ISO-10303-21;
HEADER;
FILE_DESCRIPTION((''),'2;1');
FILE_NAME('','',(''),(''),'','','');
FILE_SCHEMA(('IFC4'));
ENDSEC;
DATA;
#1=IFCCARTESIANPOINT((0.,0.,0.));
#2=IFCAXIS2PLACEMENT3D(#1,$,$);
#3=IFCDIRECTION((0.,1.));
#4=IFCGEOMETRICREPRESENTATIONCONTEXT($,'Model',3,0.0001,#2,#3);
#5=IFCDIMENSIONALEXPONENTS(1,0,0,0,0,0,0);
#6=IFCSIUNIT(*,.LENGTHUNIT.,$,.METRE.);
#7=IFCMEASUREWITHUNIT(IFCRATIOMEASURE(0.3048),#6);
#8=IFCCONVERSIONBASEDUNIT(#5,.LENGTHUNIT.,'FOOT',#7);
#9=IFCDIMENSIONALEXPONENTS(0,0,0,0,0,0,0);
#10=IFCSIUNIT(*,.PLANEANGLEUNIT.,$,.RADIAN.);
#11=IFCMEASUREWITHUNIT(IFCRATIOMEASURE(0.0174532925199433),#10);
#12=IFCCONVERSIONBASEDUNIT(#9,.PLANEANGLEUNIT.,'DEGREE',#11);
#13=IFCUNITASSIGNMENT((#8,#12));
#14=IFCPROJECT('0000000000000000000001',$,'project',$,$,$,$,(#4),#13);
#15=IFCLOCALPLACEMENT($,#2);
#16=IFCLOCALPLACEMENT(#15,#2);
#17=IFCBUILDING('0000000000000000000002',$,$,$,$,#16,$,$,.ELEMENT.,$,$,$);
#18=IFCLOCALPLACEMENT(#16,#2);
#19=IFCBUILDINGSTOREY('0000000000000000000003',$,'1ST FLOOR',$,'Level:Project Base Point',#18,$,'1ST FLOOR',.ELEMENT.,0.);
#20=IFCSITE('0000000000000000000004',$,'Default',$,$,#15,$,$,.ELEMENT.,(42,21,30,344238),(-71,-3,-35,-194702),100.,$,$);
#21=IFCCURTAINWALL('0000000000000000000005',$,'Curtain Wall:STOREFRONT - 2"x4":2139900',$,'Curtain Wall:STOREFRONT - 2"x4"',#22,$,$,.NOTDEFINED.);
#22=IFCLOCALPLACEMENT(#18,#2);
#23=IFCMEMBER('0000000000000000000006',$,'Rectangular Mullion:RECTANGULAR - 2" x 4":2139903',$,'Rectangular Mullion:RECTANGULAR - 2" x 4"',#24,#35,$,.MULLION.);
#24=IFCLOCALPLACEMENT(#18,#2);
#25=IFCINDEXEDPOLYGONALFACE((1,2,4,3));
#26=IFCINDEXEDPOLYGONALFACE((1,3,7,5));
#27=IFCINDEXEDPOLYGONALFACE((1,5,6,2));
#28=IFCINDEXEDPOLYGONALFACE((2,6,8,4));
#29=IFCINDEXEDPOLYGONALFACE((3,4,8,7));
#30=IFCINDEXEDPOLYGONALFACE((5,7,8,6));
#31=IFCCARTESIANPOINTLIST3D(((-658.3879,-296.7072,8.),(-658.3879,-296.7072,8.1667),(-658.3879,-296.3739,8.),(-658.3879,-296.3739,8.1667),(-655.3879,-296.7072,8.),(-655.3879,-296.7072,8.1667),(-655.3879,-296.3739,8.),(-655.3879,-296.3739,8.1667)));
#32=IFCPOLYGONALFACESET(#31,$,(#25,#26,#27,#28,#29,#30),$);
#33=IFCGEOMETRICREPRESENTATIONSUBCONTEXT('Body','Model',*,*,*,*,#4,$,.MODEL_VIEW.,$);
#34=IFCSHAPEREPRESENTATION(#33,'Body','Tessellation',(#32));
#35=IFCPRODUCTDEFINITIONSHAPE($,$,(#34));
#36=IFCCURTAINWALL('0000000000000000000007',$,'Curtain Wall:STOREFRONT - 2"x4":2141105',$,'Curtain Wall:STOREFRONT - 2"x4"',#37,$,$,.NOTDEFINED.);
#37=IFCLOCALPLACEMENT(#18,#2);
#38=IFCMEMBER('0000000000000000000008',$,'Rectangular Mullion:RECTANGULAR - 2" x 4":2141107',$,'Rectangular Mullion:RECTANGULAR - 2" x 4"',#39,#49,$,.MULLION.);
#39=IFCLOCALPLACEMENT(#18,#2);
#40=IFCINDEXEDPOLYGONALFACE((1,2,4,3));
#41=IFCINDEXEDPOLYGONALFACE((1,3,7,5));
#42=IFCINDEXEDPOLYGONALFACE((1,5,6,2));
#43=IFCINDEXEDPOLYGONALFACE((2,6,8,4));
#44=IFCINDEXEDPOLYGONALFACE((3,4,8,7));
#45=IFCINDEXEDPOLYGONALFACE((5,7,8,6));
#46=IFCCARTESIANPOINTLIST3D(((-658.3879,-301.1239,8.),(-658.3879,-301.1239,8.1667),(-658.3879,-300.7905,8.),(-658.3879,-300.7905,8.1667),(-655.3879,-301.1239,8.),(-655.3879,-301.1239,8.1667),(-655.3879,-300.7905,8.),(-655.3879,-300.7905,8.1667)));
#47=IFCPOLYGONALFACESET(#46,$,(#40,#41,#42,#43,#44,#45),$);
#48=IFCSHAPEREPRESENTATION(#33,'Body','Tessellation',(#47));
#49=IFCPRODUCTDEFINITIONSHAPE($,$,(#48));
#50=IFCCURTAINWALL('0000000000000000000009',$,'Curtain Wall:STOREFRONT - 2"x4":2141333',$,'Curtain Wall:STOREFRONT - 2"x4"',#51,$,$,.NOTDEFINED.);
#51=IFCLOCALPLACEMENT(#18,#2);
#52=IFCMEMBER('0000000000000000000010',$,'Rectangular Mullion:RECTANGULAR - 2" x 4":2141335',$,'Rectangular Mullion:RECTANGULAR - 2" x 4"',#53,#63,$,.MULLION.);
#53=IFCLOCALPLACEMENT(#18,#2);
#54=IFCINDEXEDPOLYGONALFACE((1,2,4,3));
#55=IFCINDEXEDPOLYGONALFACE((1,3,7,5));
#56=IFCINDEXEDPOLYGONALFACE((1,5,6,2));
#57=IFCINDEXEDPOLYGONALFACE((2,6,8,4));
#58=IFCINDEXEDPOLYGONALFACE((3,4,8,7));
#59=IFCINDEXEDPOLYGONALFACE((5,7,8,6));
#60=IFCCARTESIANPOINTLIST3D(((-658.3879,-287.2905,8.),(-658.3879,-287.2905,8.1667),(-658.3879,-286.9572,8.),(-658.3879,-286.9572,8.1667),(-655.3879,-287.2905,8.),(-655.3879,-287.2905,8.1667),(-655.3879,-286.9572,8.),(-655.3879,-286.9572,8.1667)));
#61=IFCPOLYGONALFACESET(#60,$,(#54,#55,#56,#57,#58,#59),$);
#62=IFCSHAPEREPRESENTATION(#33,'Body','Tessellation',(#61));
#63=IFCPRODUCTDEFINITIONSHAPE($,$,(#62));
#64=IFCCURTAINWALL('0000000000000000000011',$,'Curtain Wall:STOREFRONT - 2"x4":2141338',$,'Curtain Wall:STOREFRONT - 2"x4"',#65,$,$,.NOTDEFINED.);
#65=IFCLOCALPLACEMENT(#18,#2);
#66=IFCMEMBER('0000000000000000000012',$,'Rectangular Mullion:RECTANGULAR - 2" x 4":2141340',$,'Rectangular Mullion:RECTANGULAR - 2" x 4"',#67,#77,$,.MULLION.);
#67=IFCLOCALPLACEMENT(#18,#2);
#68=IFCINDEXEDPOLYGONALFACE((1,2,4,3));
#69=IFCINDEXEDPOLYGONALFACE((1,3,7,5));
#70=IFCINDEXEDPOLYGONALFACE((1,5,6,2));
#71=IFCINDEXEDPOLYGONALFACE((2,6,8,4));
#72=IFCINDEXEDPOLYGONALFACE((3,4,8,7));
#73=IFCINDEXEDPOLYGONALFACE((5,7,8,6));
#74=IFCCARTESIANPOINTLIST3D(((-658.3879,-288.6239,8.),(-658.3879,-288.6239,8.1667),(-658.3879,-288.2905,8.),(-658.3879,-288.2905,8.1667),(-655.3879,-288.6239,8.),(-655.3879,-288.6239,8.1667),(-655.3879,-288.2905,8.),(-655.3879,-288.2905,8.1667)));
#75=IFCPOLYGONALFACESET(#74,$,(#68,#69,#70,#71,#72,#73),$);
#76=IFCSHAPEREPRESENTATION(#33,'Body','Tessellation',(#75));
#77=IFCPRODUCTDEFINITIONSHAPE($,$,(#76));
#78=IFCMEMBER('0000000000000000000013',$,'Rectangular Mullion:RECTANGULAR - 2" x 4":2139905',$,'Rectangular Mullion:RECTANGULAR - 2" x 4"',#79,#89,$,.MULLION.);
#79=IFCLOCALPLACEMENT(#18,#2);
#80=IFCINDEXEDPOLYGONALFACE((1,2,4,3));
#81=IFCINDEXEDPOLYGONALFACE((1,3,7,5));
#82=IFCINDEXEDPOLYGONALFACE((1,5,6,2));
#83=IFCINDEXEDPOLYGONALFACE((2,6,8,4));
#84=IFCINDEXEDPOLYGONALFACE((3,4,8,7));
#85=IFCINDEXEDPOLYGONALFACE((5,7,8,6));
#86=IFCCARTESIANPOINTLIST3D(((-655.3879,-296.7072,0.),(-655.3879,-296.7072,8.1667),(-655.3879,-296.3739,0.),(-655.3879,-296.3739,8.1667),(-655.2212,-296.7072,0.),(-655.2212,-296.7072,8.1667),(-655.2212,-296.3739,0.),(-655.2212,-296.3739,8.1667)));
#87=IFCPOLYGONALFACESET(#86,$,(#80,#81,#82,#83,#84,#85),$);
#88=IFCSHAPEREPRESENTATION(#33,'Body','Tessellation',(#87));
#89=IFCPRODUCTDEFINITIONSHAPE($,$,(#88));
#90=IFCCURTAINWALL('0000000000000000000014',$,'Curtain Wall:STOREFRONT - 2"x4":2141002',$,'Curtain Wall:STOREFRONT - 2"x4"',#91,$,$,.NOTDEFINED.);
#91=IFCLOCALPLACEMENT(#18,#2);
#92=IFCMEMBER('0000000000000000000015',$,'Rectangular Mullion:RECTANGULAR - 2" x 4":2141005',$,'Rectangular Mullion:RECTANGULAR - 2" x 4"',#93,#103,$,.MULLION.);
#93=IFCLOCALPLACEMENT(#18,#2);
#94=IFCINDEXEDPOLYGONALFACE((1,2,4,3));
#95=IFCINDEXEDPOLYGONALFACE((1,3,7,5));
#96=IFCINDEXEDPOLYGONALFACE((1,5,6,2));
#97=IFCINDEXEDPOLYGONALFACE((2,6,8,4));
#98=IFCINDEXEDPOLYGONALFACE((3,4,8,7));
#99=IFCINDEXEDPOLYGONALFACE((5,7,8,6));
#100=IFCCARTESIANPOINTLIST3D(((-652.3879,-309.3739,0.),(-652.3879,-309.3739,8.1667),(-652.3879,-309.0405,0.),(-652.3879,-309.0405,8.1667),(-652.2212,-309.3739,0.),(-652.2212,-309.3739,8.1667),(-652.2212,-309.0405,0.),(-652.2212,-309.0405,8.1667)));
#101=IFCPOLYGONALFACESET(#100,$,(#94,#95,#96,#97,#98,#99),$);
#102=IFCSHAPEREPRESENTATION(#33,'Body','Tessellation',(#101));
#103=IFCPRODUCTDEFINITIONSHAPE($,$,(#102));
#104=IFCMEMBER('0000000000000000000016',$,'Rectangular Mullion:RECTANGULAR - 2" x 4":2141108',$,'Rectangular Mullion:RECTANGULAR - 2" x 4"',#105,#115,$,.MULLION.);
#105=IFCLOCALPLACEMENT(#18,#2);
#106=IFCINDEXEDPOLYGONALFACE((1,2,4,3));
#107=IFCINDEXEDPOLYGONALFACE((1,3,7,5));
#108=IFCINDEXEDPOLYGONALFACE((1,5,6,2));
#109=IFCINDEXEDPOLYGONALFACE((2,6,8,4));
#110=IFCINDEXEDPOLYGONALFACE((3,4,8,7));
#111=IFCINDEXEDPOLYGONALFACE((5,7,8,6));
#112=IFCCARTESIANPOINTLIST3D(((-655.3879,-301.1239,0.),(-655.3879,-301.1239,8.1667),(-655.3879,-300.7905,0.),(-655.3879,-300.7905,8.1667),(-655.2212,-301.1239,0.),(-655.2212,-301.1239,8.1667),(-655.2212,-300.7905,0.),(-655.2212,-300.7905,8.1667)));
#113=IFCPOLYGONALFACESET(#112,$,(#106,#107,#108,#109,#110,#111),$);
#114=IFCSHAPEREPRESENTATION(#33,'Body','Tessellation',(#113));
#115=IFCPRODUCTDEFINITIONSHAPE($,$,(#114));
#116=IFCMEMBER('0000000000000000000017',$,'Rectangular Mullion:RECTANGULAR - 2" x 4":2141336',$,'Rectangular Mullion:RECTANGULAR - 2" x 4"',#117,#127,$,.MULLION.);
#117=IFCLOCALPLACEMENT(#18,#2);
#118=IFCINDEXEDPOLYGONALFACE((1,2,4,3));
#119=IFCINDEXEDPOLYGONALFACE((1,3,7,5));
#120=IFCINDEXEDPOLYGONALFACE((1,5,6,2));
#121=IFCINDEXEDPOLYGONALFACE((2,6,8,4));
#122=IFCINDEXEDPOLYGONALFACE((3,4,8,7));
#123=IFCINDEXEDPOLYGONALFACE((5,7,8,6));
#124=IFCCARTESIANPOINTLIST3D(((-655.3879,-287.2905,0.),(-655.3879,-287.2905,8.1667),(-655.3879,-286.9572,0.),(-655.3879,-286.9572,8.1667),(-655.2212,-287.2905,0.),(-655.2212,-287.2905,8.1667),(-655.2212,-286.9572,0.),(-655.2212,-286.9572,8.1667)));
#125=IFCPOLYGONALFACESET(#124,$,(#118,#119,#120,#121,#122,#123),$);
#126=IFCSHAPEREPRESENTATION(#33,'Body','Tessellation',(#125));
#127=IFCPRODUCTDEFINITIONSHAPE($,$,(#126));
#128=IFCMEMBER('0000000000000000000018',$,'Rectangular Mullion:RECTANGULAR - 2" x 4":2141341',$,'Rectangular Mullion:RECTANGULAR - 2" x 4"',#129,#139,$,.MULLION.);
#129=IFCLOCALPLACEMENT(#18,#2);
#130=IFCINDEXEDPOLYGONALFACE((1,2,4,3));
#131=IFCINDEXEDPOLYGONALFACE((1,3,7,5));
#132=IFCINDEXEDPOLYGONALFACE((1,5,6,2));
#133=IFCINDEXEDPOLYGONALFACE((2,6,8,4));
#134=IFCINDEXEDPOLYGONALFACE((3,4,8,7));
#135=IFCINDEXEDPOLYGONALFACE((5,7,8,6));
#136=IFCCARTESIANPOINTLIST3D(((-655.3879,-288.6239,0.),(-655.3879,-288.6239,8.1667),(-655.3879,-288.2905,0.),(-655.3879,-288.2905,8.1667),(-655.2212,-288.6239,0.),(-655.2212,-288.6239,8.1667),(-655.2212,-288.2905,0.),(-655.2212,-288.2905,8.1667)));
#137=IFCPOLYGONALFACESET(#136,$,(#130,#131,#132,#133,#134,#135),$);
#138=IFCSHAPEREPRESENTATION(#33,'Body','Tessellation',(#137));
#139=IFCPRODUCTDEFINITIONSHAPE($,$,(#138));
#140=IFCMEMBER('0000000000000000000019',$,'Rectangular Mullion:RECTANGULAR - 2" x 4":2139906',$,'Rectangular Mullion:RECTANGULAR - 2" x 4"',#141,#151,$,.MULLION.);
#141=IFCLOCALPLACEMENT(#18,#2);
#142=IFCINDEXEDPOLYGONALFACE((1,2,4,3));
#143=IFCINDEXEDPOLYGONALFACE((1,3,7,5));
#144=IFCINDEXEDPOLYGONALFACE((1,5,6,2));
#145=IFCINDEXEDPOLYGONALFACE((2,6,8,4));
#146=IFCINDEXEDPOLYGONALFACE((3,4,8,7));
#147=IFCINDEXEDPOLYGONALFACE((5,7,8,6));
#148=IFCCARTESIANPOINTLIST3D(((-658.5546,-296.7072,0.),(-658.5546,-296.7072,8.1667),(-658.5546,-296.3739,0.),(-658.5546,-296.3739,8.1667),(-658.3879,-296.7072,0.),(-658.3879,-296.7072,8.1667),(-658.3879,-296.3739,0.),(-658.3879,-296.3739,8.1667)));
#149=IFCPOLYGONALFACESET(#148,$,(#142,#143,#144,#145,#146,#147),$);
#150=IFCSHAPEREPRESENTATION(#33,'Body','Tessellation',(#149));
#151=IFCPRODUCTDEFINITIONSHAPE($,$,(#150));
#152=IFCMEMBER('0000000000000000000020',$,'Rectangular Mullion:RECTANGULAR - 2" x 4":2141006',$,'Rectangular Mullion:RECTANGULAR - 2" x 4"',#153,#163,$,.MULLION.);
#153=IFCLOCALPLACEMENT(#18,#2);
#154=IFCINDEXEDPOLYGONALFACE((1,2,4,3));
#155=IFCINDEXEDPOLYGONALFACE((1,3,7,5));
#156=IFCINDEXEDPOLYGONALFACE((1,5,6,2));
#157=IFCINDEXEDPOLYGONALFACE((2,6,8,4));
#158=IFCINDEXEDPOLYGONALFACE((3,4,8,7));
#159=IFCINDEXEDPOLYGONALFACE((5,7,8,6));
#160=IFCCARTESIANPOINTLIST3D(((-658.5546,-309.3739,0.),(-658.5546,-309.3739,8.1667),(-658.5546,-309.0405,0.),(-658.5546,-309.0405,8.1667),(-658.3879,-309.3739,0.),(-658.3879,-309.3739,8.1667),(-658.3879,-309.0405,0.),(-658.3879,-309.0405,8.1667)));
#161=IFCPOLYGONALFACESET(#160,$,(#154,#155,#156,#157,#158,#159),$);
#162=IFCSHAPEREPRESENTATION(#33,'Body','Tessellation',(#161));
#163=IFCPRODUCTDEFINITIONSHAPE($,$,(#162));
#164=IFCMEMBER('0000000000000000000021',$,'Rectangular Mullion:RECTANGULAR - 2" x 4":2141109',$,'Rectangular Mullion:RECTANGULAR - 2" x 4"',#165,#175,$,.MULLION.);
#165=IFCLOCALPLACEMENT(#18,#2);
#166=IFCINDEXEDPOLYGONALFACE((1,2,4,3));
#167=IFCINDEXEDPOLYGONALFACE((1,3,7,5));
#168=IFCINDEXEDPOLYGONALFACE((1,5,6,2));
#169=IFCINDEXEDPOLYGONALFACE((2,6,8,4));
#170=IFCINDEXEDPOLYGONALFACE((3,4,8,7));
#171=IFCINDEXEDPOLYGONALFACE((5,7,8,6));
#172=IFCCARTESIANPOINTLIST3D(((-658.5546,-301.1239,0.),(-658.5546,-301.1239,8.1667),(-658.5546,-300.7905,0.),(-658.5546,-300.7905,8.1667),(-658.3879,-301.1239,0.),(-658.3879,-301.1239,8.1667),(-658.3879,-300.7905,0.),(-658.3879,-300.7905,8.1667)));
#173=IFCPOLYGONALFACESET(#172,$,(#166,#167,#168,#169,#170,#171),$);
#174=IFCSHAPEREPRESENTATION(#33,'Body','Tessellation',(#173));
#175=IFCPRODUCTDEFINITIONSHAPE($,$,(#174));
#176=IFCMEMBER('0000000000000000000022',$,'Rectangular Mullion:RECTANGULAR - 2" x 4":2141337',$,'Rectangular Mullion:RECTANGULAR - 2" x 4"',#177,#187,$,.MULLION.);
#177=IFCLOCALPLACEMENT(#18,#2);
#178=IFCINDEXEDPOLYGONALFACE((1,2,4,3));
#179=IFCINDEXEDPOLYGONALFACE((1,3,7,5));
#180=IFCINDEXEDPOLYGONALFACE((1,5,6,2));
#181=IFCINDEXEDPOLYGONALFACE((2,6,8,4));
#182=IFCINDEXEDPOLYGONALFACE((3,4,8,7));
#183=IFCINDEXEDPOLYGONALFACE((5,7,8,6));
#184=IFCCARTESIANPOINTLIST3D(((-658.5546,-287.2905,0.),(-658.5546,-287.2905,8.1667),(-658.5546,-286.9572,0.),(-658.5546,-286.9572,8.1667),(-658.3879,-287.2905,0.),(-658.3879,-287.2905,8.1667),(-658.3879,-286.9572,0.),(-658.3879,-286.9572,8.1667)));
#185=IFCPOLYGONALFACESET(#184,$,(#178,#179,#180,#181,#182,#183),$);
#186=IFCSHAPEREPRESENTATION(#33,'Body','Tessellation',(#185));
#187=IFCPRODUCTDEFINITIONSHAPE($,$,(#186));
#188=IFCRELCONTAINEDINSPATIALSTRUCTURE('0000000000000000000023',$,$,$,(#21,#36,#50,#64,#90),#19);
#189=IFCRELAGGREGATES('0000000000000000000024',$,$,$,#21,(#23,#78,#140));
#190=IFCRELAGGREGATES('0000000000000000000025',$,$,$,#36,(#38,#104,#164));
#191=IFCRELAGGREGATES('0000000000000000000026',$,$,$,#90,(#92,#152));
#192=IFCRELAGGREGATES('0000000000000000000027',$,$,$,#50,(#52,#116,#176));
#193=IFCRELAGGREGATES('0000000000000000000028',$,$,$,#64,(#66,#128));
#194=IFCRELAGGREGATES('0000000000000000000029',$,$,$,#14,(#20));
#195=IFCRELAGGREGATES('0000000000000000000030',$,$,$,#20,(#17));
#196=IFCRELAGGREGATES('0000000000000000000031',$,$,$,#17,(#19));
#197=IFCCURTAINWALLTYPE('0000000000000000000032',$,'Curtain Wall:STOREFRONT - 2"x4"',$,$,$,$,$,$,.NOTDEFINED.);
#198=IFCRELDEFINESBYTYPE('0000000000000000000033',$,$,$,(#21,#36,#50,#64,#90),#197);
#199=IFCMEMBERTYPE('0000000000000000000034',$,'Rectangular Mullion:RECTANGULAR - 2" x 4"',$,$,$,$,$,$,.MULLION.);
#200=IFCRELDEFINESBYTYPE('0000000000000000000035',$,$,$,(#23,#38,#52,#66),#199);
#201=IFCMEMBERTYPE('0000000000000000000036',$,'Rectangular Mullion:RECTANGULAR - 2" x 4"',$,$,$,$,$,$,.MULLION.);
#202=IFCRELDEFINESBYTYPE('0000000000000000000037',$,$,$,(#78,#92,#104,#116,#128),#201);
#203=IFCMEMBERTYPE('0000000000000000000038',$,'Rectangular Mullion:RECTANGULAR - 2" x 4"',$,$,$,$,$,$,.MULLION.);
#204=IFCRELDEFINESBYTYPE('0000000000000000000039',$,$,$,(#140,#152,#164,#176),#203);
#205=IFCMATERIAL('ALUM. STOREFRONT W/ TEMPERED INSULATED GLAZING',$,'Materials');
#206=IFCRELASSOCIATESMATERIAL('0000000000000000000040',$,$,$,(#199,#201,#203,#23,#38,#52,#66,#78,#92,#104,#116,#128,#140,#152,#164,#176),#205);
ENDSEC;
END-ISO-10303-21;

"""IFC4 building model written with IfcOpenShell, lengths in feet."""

from ifc_helpers import new_model, entity, si_unit, converted_unit, direction, frame, origin, origin_2d_with_axis, place, context, subcontext, project, spatial, rectangle, extrude, source, transform, mapped, material, material_profile, profile_set, profile_usage, type_object, type_shapes, element, aggregate, save


model = new_model("IFC4")

# Units and contexts
model_context = context("Model", 3, precision=0.0001, world=origin(), true_north=direction((0.0, 1.0)))
body_context = subcontext(model_context, "Body", "Model", "MODEL_VIEW")
ifc_project = project(units=[converted_unit("LENGTHUNIT", "FOOT", entity("IfcRatioMeasure", 0.3048), si_unit("LENGTHUNIT", "METRE"), dimensions=[1, 0, 0, 0, 0, 0, 0]), converted_unit("PLANEANGLEUNIT", "DEGREE", entity("IfcRatioMeasure", 0.0174532925199433), si_unit("PLANEANGLEUNIT", "RADIAN"), dimensions=[0, 0, 0, 0, 0, 0, 0])], contexts=[model_context])

# Site, building, storey
site_placement = place(None, origin())
site = spatial("IfcSite", under=ifc_project, at=site_placement, Name="Default", CompositionType="ELEMENT", RefLatitude=(42, 21, 30, 344238), RefLongitude=(-71, -3, -35, -194702), RefElevation=100.0)
building_placement = place(site_placement, origin())
building = spatial("IfcBuilding", under=site, at=building_placement, CompositionType="ELEMENT")
storey_placement = place(building_placement, origin())
storey = spatial("IfcBuildingStorey", under=building, at=storey_placement, Name="1ST FLOOR", ObjectType="Level:Project Base Point", LongName="1ST FLOOR", CompositionType="ELEMENT", Elevation=0.0)

# Curtain walls, members
curtain_wall_type = type_object("IfcCurtainWallType", Name="Curtain Wall:STOREFRONT - 2\"x4\"", PredefinedType="NOTDEFINED")
curtain_wall_1_placement = place(storey_placement, origin())
curtain_wall_1 = element("IfcCurtainWall", 1, at=curtain_wall_1_placement, inside=storey, type_object=curtain_wall_type, Name="Curtain Wall:STOREFRONT - 2\"x4\":2139900", ObjectType="Curtain Wall:STOREFRONT - 2\"x4\"", PredefinedType="NOTDEFINED")
ifc_material_1 = material(Name="ALUM. STOREFRONT W/ TEMPERED INSULATED GLAZING", Category="Materials")
ifc_material_profile = material_profile(ifc_material_1, rectangle(XDim=0.3333, YDim=0.1667, at=origin_2d_with_axis()), Name="RECTANGULAR - 2\" x 4\"")
ifc_profile_set = profile_set([ifc_material_profile], Name="RECTANGULAR - 2\" x 4\"")
ifc_profile_usage_1 = profile_usage(ifc_profile_set)
member_type_1 = type_object("IfcMemberType", Name="Rectangular Mullion:RECTANGULAR - 2\" x 4\"", PredefinedType="MULLION", material=ifc_profile_set)
shared_shape_1 = source(origin(), body_context, "Body", "SweptSolid", [
    extrude(rectangle(XDim=0.3333, YDim=0.1667, at=origin_2d_with_axis()), frame((-0.0833, 0.0, -3.0), z_axis=(0.0, 0.0, 1.0), x_axis=(0.0, -1.0, 0.0)), (0.0, 0.0, 1.0), 3.0),
])
type_shapes(member_type_1, [shared_shape_1])
member_1_placement = place(storey_placement, frame((-655.3879, -296.5405, 8.1667), z_axis=(1.0, 0.0, 0.0), x_axis=(0.0, 0.0, 1.0)))
member_1 = element("IfcMember", 2, at=member_1_placement, type_object=member_type_1, material=ifc_profile_usage_1, Name="Rectangular Mullion:RECTANGULAR - 2\" x 4\":2139903", ObjectType="Rectangular Mullion:RECTANGULAR - 2\" x 4\"", PredefinedType="MULLION", context=body_context, shape_type="MappedRepresentation", body=[
    mapped(shared_shape_1, transform((0.0, 0.0, 0.0), scale=1.0)),
])
curtain_wall_2_placement = place(storey_placement, origin())
curtain_wall_2 = element("IfcCurtainWall", 3, at=curtain_wall_2_placement, inside=storey, type_object=curtain_wall_type, Name="Curtain Wall:STOREFRONT - 2\"x4\":2141105", ObjectType="Curtain Wall:STOREFRONT - 2\"x4\"", PredefinedType="NOTDEFINED")
ifc_profile_usage_2 = profile_usage(ifc_profile_set)
member_2_placement = place(storey_placement, frame((-655.3879, -300.9572, 8.1667), z_axis=(1.0, 0.0, 0.0), x_axis=(0.0, 0.0, 1.0)))
member_2 = element("IfcMember", 4, at=member_2_placement, type_object=member_type_1, material=ifc_profile_usage_2, Name="Rectangular Mullion:RECTANGULAR - 2\" x 4\":2141107", ObjectType="Rectangular Mullion:RECTANGULAR - 2\" x 4\"", PredefinedType="MULLION", context=body_context, shape_type="MappedRepresentation", body=[
    mapped(shared_shape_1, transform((0.0, 0.0, 0.0), scale=1.0)),
])
curtain_wall_3_placement = place(storey_placement, origin())
curtain_wall_3 = element("IfcCurtainWall", 5, at=curtain_wall_3_placement, inside=storey, type_object=curtain_wall_type, Name="Curtain Wall:STOREFRONT - 2\"x4\":2141333", ObjectType="Curtain Wall:STOREFRONT - 2\"x4\"", PredefinedType="NOTDEFINED")
ifc_profile_usage_3 = profile_usage(ifc_profile_set)
member_3_placement = place(storey_placement, frame((-655.3879, -287.1239, 8.1667), z_axis=(1.0, 0.0, 0.0), x_axis=(0.0, 0.0, 1.0)))
member_3 = element("IfcMember", 6, at=member_3_placement, type_object=member_type_1, material=ifc_profile_usage_3, Name="Rectangular Mullion:RECTANGULAR - 2\" x 4\":2141335", ObjectType="Rectangular Mullion:RECTANGULAR - 2\" x 4\"", PredefinedType="MULLION", context=body_context, shape_type="MappedRepresentation", body=[
    mapped(shared_shape_1, transform((0.0, 0.0, 0.0), scale=1.0)),
])
curtain_wall_4_placement = place(storey_placement, origin())
curtain_wall_4 = element("IfcCurtainWall", 7, at=curtain_wall_4_placement, inside=storey, type_object=curtain_wall_type, Name="Curtain Wall:STOREFRONT - 2\"x4\":2141338", ObjectType="Curtain Wall:STOREFRONT - 2\"x4\"", PredefinedType="NOTDEFINED")
ifc_profile_usage_4 = profile_usage(ifc_profile_set)
member_4_placement = place(storey_placement, frame((-655.3879, -288.4572, 8.1667), z_axis=(1.0, 0.0, 0.0), x_axis=(0.0, 0.0, 1.0)))
member_4 = element("IfcMember", 8, at=member_4_placement, type_object=member_type_1, material=ifc_profile_usage_4, Name="Rectangular Mullion:RECTANGULAR - 2\" x 4\":2141340", ObjectType="Rectangular Mullion:RECTANGULAR - 2\" x 4\"", PredefinedType="MULLION", context=body_context, shape_type="MappedRepresentation", body=[
    mapped(shared_shape_1, transform((0.0, 0.0, 0.0), scale=1.0)),
])

# Member
ifc_profile_usage_5 = profile_usage(ifc_profile_set)
member_type_2 = type_object("IfcMemberType", Name="Rectangular Mullion:RECTANGULAR - 2\" x 4\"", PredefinedType="MULLION", material=ifc_profile_set)
shared_shape_2 = source(origin(), body_context, "Body", "SweptSolid", [
    extrude(rectangle(XDim=0.3333, YDim=0.1667, at=origin_2d_with_axis()), frame((-0.0833, 0.0, -8.1667), z_axis=(0.0, 0.0, 1.0), x_axis=(0.0, -1.0, 0.0)), (0.0, 0.0, 1.0), 8.1667),
])
type_shapes(member_type_2, [shared_shape_2])
member_5_placement = place(storey_placement, frame((-655.2212, -296.5405, 0.0), z_axis=(0.0, 0.0, -1.0), x_axis=(1.0, 0.0, 0.0)))
member_5 = element("IfcMember", 9, at=member_5_placement, type_object=member_type_2, material=ifc_profile_usage_5, Name="Rectangular Mullion:RECTANGULAR - 2\" x 4\":2139905", ObjectType="Rectangular Mullion:RECTANGULAR - 2\" x 4\"", PredefinedType="MULLION", context=body_context, shape_type="MappedRepresentation", body=[
    mapped(shared_shape_2, transform((0.0, 0.0, 0.0), scale=1.0)),
])

# Curtain wall, member
curtain_wall_5_placement = place(storey_placement, origin())
curtain_wall_5 = element("IfcCurtainWall", 10, at=curtain_wall_5_placement, inside=storey, type_object=curtain_wall_type, Name="Curtain Wall:STOREFRONT - 2\"x4\":2141002", ObjectType="Curtain Wall:STOREFRONT - 2\"x4\"", PredefinedType="NOTDEFINED")
ifc_profile_usage_6 = profile_usage(ifc_profile_set)
member_6_placement = place(storey_placement, frame((-652.2212, -309.2072, 0.0), z_axis=(0.0, 0.0, -1.0), x_axis=(1.0, 0.0, 0.0)))
member_6 = element("IfcMember", 11, at=member_6_placement, type_object=member_type_2, material=ifc_profile_usage_6, Name="Rectangular Mullion:RECTANGULAR - 2\" x 4\":2141005", ObjectType="Rectangular Mullion:RECTANGULAR - 2\" x 4\"", PredefinedType="MULLION", context=body_context, shape_type="MappedRepresentation", body=[
    mapped(shared_shape_2, transform((0.0, 0.0, 0.0), scale=1.0)),
])

# Members
ifc_profile_usage_7 = profile_usage(ifc_profile_set)
member_7_placement = place(storey_placement, frame((-655.2212, -300.9572, 0.0), z_axis=(0.0, 0.0, -1.0), x_axis=(1.0, 0.0, 0.0)))
member_7 = element("IfcMember", 12, at=member_7_placement, type_object=member_type_2, material=ifc_profile_usage_7, Name="Rectangular Mullion:RECTANGULAR - 2\" x 4\":2141108", ObjectType="Rectangular Mullion:RECTANGULAR - 2\" x 4\"", PredefinedType="MULLION", context=body_context, shape_type="MappedRepresentation", body=[
    mapped(shared_shape_2, transform((0.0, 0.0, 0.0), scale=1.0)),
])
ifc_profile_usage_8 = profile_usage(ifc_profile_set)
member_8_placement = place(storey_placement, frame((-655.2212, -287.1239, 0.0), z_axis=(0.0, 0.0, -1.0), x_axis=(1.0, 0.0, 0.0)))
member_8 = element("IfcMember", 13, at=member_8_placement, type_object=member_type_2, material=ifc_profile_usage_8, Name="Rectangular Mullion:RECTANGULAR - 2\" x 4\":2141336", ObjectType="Rectangular Mullion:RECTANGULAR - 2\" x 4\"", PredefinedType="MULLION", context=body_context, shape_type="MappedRepresentation", body=[
    mapped(shared_shape_2, transform((0.0, 0.0, 0.0), scale=1.0)),
])
ifc_profile_usage_9 = profile_usage(ifc_profile_set)
member_9_placement = place(storey_placement, frame((-655.2212, -288.4572, 0.0), z_axis=(0.0, 0.0, -1.0), x_axis=(1.0, 0.0, 0.0)))
member_9 = element("IfcMember", 14, at=member_9_placement, type_object=member_type_2, material=ifc_profile_usage_9, Name="Rectangular Mullion:RECTANGULAR - 2\" x 4\":2141341", ObjectType="Rectangular Mullion:RECTANGULAR - 2\" x 4\"", PredefinedType="MULLION", context=body_context, shape_type="MappedRepresentation", body=[
    mapped(shared_shape_2, transform((0.0, 0.0, 0.0), scale=1.0)),
])
ifc_profile_usage_10 = profile_usage(ifc_profile_set)
member_type_3 = type_object("IfcMemberType", Name="Rectangular Mullion:RECTANGULAR - 2\" x 4\"", PredefinedType="MULLION", material=ifc_profile_set)
shared_shape_3 = source(origin(), body_context, "Body", "SweptSolid", [
    extrude(rectangle(XDim=0.3333, YDim=0.1667, at=origin_2d_with_axis()), frame((-0.0833, 0.0, -8.1667), z_axis=(0.0, 0.0, 1.0), x_axis=(0.0, -1.0, 0.0)), (0.0, 0.0, 1.0), 8.1667),
])
type_shapes(member_type_3, [shared_shape_3])
member_10_placement = place(storey_placement, frame((-658.5546, -296.5405, 8.1667), z_axis=(0.0, 0.0, 1.0), x_axis=(-1.0, 0.0, 0.0)))
member_10 = element("IfcMember", 15, at=member_10_placement, type_object=member_type_3, material=ifc_profile_usage_10, Name="Rectangular Mullion:RECTANGULAR - 2\" x 4\":2139906", ObjectType="Rectangular Mullion:RECTANGULAR - 2\" x 4\"", PredefinedType="MULLION", context=body_context, shape_type="MappedRepresentation", body=[
    mapped(shared_shape_3, transform((0.0, 0.0, 0.0), scale=1.0)),
])
aggregate(curtain_wall_1, [member_1, member_5, member_10])
ifc_profile_usage_11 = profile_usage(ifc_profile_set)
member_11_placement = place(storey_placement, frame((-658.5546, -309.2072, 8.1667), z_axis=(0.0, 0.0, 1.0), x_axis=(-1.0, 0.0, 0.0)))
member_11 = element("IfcMember", 16, at=member_11_placement, type_object=member_type_3, material=ifc_profile_usage_11, Name="Rectangular Mullion:RECTANGULAR - 2\" x 4\":2141006", ObjectType="Rectangular Mullion:RECTANGULAR - 2\" x 4\"", PredefinedType="MULLION", context=body_context, shape_type="MappedRepresentation", body=[
    mapped(shared_shape_3, transform((0.0, 0.0, 0.0), scale=1.0)),
])
ifc_profile_usage_12 = profile_usage(ifc_profile_set)
member_12_placement = place(storey_placement, frame((-658.5546, -300.9572, 8.1667), z_axis=(0.0, 0.0, 1.0), x_axis=(-1.0, 0.0, 0.0)))
member_12 = element("IfcMember", 17, at=member_12_placement, type_object=member_type_3, material=ifc_profile_usage_12, Name="Rectangular Mullion:RECTANGULAR - 2\" x 4\":2141109", ObjectType="Rectangular Mullion:RECTANGULAR - 2\" x 4\"", PredefinedType="MULLION", context=body_context, shape_type="MappedRepresentation", body=[
    mapped(shared_shape_3, transform((0.0, 0.0, 0.0), scale=1.0)),
])
aggregate(curtain_wall_2, [member_2, member_7, member_12])
ifc_profile_usage_13 = profile_usage(ifc_profile_set)
member_13_placement = place(storey_placement, frame((-658.5546, -287.1239, 8.1667), z_axis=(0.0, 0.0, 1.0), x_axis=(-1.0, 0.0, 0.0)))
member_13 = element("IfcMember", 18, at=member_13_placement, type_object=member_type_3, material=ifc_profile_usage_13, Name="Rectangular Mullion:RECTANGULAR - 2\" x 4\":2141337", ObjectType="Rectangular Mullion:RECTANGULAR - 2\" x 4\"", PredefinedType="MULLION", context=body_context, shape_type="MappedRepresentation", body=[
    mapped(shared_shape_3, transform((0.0, 0.0, 0.0), scale=1.0)),
])
aggregate(curtain_wall_5, [member_6, member_11])

aggregate(curtain_wall_3, [member_3, member_8, member_13])
aggregate(curtain_wall_4, [member_4, member_9])

save(model, "model.ifc")
